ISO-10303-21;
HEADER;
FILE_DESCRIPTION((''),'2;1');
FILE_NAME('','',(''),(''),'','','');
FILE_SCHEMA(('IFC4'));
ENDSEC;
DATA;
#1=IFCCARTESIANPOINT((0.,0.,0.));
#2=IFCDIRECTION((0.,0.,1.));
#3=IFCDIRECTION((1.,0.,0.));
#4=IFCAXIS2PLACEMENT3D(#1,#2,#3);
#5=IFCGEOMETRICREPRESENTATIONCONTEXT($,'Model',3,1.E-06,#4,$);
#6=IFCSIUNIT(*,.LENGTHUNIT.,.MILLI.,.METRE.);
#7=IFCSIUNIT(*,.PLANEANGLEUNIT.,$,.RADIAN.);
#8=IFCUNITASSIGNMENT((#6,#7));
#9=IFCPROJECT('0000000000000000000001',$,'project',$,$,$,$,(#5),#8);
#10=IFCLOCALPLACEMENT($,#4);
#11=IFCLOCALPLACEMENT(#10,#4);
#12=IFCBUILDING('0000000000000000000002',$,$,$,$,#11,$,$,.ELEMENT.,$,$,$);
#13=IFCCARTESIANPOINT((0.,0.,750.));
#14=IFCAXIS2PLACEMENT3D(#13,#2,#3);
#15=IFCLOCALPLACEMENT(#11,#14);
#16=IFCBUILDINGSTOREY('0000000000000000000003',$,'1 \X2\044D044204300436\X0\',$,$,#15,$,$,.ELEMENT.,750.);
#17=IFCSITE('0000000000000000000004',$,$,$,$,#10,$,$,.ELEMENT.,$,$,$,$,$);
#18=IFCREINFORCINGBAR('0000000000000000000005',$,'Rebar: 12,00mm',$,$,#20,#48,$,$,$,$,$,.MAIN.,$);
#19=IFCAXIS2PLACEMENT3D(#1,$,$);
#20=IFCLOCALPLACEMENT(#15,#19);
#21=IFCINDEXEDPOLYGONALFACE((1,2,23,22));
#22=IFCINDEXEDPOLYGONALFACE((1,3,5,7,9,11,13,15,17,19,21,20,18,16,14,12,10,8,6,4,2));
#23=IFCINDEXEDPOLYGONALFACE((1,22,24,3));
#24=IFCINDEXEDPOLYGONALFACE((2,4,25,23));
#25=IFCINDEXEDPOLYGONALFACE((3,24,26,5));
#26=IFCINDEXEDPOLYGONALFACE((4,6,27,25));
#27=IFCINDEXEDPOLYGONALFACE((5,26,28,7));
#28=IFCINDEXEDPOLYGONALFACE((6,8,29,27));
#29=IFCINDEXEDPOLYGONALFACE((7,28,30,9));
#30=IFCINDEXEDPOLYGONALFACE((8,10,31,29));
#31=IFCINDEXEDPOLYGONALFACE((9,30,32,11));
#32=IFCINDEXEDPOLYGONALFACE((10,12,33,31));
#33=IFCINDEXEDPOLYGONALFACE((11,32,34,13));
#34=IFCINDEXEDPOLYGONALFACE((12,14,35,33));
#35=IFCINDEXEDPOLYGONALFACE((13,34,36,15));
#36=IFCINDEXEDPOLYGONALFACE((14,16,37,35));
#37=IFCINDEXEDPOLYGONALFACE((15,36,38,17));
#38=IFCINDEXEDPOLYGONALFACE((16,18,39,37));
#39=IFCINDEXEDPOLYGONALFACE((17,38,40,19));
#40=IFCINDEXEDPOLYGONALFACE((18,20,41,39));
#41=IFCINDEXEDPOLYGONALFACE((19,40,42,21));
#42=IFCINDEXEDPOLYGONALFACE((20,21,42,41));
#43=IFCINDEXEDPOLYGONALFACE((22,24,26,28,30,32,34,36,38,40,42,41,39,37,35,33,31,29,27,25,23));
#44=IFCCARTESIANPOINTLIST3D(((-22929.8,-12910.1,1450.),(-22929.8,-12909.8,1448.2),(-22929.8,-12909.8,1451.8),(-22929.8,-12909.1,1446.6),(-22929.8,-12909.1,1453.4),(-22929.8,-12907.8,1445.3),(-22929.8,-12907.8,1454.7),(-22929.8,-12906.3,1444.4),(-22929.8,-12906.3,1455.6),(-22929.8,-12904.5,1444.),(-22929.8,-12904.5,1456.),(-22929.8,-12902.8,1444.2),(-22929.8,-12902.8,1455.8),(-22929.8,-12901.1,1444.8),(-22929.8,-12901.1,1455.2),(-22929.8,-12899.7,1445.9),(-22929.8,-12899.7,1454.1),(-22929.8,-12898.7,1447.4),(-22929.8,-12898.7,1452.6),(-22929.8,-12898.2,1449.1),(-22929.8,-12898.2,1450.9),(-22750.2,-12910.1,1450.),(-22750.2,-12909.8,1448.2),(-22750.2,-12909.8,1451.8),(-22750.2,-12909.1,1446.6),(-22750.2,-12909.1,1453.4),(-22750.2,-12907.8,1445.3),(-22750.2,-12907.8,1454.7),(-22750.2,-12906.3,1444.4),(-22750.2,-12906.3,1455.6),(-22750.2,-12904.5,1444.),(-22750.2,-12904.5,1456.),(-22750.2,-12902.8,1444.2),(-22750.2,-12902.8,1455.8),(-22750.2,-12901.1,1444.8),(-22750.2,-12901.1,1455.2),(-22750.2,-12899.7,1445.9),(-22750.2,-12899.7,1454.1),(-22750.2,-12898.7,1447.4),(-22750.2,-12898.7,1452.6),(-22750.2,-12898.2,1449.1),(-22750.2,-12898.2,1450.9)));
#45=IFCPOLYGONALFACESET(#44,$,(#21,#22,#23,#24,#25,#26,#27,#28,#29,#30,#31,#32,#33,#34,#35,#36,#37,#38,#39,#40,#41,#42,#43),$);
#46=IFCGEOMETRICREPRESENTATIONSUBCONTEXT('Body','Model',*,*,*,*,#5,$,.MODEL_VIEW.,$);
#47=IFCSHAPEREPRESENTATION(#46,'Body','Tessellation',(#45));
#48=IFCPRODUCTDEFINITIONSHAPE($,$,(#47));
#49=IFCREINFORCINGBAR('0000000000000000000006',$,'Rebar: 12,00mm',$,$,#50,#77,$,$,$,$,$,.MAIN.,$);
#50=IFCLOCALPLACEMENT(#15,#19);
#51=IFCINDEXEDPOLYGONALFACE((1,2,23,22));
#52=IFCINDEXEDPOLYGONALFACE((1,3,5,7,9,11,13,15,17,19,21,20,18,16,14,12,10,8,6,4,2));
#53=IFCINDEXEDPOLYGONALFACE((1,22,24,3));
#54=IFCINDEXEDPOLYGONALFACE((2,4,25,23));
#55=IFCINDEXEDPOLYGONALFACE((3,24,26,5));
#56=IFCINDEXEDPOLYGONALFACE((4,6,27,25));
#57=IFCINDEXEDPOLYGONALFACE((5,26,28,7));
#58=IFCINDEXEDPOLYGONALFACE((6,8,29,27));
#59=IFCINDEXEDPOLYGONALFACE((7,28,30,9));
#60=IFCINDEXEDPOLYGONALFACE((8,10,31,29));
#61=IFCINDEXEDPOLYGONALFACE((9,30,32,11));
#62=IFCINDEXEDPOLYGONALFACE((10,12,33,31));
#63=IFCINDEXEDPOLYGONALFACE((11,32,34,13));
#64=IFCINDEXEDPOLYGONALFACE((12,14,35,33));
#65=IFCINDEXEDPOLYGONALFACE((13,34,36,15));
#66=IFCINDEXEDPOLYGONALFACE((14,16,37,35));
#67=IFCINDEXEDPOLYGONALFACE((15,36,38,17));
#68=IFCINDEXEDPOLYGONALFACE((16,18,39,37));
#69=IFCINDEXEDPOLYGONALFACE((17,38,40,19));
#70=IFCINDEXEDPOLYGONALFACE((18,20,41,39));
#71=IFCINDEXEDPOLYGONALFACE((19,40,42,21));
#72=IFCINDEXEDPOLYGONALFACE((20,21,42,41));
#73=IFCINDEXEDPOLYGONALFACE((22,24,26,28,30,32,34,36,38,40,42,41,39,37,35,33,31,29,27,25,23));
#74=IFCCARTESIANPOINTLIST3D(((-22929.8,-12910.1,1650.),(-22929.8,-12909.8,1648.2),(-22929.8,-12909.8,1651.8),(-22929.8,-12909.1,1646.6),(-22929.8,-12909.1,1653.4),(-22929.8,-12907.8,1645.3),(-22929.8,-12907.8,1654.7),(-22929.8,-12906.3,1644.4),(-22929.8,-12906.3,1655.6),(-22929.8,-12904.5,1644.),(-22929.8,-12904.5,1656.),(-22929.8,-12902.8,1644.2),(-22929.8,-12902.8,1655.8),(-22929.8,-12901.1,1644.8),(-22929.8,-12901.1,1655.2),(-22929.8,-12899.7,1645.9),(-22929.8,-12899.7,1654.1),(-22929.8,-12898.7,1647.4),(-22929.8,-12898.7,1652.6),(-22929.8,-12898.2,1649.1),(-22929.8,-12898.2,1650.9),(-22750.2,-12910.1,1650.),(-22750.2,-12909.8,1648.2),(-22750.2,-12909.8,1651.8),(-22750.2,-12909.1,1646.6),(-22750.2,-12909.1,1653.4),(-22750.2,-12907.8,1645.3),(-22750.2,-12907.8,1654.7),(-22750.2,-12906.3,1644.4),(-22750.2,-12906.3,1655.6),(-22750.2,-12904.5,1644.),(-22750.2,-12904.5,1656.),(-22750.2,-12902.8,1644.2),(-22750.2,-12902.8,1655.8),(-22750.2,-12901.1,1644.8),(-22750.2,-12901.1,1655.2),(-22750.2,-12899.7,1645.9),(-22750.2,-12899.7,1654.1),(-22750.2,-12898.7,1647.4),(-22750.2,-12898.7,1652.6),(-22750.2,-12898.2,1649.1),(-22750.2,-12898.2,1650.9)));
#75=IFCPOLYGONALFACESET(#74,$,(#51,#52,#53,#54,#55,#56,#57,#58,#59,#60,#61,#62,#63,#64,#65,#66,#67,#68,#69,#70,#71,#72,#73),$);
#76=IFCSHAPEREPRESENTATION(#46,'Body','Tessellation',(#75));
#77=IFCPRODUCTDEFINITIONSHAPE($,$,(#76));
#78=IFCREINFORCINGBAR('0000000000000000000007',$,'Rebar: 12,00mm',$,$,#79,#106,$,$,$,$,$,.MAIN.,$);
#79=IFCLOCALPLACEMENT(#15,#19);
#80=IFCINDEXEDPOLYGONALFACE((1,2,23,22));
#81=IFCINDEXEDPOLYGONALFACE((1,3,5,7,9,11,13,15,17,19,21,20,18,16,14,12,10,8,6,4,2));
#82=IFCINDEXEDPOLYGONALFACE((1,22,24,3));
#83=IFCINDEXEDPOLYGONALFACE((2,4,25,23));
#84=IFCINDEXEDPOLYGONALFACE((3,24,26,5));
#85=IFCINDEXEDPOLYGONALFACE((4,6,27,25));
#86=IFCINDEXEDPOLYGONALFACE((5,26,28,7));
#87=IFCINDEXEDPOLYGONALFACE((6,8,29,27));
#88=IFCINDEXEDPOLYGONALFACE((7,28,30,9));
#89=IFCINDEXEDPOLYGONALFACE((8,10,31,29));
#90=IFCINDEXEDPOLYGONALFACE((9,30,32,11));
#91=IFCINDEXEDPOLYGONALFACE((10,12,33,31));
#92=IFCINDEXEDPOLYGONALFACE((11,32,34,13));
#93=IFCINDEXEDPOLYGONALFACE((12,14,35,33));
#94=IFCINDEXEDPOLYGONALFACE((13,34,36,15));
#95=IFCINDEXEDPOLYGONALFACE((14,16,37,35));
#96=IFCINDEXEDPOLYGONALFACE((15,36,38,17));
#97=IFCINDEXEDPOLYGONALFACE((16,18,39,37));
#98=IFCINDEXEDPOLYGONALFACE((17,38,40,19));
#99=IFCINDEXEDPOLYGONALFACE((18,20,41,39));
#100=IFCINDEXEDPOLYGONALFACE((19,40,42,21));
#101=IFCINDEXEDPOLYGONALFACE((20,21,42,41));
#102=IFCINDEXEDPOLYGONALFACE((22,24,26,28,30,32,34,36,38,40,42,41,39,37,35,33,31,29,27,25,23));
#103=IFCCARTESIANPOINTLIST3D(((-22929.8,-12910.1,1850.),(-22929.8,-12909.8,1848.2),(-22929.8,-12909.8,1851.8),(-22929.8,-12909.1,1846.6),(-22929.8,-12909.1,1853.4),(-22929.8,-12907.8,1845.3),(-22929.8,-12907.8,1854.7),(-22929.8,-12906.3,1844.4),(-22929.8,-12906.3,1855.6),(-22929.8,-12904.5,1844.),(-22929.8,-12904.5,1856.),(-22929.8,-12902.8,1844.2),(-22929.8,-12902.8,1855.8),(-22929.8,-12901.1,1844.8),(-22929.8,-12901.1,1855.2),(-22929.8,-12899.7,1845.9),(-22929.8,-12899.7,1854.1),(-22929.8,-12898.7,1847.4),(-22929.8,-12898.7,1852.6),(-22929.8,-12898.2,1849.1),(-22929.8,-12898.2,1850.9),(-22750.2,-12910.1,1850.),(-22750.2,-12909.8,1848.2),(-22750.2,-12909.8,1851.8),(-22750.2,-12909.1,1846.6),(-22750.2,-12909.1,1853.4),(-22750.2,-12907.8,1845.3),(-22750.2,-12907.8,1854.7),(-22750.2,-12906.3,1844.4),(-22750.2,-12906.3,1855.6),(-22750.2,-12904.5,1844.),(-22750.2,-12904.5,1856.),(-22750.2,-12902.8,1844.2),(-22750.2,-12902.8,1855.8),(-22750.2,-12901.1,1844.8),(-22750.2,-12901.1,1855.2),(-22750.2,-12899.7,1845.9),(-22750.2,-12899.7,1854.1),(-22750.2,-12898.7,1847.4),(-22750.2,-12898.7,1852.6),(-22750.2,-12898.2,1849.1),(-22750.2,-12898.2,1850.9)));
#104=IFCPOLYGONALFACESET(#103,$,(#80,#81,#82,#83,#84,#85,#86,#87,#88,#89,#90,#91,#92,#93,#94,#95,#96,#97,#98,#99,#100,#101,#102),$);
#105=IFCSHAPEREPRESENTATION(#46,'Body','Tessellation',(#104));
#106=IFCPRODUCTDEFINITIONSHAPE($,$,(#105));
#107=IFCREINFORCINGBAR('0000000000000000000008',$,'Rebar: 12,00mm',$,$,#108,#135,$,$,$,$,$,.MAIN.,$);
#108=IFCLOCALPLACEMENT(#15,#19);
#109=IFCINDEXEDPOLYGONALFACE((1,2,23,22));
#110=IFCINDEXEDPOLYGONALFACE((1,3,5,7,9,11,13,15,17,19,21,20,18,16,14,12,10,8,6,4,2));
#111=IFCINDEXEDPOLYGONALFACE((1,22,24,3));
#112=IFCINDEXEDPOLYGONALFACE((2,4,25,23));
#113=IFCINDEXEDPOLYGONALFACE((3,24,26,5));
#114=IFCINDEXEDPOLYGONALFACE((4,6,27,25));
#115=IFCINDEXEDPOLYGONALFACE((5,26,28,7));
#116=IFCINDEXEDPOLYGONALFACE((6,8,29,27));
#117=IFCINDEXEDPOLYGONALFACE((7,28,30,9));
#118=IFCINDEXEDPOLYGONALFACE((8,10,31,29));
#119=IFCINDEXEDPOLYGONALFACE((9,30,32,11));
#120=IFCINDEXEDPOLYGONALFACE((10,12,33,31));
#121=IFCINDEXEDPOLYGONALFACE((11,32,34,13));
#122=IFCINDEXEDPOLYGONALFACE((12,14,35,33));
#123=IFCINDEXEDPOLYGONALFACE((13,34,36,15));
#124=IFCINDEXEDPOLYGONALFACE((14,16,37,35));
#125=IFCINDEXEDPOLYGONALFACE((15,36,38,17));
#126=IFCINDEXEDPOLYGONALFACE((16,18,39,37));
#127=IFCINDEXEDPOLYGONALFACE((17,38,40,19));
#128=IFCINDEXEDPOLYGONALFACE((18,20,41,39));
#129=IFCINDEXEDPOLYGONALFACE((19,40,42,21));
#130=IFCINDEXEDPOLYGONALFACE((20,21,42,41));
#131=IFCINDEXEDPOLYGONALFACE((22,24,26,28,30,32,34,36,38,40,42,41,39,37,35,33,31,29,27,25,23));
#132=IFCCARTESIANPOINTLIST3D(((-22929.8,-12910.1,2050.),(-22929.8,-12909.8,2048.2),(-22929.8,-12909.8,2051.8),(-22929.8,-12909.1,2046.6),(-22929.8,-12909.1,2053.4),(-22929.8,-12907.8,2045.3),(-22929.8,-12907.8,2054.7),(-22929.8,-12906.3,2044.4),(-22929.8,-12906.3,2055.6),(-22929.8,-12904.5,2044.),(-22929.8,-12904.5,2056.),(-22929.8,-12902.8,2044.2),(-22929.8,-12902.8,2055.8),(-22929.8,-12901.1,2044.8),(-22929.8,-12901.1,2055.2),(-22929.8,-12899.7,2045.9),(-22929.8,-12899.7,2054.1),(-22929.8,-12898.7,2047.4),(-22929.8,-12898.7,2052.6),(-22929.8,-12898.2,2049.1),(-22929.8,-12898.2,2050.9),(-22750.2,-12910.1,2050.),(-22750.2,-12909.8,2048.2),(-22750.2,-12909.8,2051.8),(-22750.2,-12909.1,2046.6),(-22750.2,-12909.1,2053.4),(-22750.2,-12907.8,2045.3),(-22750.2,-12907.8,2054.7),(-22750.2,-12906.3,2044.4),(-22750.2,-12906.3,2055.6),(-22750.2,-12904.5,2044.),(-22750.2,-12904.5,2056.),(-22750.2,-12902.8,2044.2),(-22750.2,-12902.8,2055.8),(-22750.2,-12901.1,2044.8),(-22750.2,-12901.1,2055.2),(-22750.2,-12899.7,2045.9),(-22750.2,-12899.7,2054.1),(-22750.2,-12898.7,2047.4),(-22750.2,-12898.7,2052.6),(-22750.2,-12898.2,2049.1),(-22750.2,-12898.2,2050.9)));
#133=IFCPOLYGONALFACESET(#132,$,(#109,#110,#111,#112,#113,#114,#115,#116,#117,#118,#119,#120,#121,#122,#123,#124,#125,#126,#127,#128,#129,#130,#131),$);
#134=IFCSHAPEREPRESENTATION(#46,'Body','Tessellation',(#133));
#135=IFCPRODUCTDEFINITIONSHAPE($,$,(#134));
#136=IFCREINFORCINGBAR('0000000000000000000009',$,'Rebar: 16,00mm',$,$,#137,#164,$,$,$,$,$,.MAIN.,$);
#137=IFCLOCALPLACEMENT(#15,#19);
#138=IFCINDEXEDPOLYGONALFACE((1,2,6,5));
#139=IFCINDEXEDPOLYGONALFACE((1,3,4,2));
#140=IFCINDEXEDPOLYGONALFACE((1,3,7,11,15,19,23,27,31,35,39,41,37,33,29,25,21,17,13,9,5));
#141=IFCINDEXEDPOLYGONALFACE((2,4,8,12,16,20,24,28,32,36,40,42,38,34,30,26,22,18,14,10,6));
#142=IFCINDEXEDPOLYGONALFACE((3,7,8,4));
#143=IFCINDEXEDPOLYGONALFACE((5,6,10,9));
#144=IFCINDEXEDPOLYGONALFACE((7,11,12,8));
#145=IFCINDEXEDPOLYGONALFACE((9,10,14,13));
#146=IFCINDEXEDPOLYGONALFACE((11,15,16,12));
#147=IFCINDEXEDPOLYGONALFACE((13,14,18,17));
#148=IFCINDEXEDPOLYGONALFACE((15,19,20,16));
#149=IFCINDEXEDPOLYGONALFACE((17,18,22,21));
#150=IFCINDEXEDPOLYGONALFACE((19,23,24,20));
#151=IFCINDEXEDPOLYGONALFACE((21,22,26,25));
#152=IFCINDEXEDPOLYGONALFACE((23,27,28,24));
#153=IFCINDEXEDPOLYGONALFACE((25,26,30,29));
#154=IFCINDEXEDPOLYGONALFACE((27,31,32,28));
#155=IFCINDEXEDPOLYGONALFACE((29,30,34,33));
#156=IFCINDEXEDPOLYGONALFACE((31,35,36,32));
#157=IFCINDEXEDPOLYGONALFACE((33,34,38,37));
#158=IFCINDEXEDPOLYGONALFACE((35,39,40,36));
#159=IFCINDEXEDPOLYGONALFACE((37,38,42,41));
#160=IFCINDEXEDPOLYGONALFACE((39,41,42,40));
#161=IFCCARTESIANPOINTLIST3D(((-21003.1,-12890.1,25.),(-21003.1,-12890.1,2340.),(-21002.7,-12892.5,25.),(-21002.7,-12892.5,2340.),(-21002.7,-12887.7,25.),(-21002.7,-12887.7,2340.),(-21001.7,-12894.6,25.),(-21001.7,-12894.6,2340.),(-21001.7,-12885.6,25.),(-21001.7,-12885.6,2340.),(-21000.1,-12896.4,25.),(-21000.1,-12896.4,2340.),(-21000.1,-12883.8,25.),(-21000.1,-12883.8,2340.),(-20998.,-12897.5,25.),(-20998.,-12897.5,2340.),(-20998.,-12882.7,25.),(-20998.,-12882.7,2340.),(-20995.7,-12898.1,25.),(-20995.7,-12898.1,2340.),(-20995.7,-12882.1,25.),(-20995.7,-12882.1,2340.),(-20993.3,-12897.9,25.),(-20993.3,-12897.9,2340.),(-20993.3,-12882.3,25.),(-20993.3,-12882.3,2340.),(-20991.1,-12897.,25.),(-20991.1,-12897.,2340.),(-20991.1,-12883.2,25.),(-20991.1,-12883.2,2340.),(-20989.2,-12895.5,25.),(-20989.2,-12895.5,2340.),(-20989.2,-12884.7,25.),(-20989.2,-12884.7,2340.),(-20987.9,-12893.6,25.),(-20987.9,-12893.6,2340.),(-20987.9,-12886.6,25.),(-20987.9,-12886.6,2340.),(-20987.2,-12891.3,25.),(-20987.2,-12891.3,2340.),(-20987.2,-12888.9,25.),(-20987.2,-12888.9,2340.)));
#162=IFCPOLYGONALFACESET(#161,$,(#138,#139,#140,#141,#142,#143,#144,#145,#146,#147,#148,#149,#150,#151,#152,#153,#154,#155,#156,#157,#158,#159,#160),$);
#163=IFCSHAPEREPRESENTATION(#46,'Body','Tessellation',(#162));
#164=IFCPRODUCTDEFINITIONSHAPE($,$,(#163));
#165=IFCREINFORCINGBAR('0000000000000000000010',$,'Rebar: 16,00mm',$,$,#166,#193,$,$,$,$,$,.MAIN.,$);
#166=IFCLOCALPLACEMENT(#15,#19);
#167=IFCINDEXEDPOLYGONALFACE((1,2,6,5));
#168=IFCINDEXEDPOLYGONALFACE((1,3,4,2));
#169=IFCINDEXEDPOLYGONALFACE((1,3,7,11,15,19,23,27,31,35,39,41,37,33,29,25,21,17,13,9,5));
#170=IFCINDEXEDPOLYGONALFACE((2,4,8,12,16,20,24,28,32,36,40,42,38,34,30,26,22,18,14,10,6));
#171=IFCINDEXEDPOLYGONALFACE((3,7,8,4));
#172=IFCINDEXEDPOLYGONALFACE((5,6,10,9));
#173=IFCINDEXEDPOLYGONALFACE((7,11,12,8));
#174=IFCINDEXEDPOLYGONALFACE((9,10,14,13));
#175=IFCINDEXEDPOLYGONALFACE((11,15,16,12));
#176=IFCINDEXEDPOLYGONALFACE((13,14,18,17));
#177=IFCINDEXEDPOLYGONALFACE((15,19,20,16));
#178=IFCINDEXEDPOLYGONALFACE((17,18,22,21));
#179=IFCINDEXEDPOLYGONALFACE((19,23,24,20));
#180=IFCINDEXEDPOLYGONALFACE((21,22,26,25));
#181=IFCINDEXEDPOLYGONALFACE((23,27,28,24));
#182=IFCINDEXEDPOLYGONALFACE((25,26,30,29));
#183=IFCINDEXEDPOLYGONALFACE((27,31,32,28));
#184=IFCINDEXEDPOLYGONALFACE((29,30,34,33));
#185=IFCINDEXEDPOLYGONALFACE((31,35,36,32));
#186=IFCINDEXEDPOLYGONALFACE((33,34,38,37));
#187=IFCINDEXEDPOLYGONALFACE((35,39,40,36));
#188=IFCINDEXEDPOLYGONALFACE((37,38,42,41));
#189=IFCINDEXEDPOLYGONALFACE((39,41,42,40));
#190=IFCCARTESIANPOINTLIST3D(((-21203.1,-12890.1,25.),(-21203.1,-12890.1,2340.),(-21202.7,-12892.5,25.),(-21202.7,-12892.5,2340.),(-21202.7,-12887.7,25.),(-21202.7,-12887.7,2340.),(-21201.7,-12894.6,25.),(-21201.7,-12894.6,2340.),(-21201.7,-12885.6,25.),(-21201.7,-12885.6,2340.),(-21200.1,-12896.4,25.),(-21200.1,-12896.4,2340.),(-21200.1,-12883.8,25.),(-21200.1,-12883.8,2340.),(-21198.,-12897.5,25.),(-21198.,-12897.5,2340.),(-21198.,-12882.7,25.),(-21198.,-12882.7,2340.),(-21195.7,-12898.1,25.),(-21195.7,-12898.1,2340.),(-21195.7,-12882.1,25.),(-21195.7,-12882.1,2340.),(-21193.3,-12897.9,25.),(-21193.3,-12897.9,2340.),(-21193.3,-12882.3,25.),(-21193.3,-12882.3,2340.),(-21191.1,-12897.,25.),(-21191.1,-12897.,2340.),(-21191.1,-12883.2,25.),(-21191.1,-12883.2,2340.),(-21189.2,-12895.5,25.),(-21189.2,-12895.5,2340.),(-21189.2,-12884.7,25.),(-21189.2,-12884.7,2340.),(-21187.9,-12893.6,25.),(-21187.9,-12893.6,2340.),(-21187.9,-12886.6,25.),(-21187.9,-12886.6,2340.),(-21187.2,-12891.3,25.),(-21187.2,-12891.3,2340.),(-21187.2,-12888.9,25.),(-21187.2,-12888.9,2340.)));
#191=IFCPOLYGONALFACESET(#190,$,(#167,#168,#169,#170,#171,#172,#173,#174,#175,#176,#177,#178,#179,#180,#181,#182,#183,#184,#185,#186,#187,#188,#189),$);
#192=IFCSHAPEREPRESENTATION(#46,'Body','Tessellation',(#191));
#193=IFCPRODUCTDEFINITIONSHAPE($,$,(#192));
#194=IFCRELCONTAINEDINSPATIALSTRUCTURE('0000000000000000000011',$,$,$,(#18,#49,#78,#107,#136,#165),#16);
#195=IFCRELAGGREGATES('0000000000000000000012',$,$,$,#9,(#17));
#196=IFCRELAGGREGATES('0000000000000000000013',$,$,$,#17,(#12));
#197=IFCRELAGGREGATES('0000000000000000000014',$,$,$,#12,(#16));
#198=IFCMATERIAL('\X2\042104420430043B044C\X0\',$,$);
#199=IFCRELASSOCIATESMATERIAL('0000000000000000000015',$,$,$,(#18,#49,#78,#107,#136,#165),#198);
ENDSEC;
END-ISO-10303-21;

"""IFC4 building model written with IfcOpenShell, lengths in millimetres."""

from ifc_helpers import new_model, entity, si_unit, frame, origin_with_axes, place, context, subcontext, project, spatial, source, transform, mapped, material, element, save


model = new_model("IFC4")

# Units and contexts
model_context = context("Model", 3, precision=1e-06, world=origin_with_axes())
body_context = subcontext(model_context, "Body", "Model", "MODEL_VIEW")
ifc_project = project(units=[si_unit("LENGTHUNIT", "METRE", prefix="MILLI"), si_unit("PLANEANGLEUNIT", "RADIAN")], contexts=[model_context])

# Site, building, storey
site_placement = place(None, origin_with_axes())
site = spatial("IfcSite", under=ifc_project, at=site_placement, CompositionType="ELEMENT")
building_placement = place(site_placement, origin_with_axes())
building = spatial("IfcBuilding", under=site, at=building_placement, CompositionType="ELEMENT")
storey_placement = place(building_placement, frame((0.0, 0.0, 750.0), z_axis=(0.0, 0.0, 1.0), x_axis=(1.0, 0.0, 0.0)))
storey = spatial("IfcBuildingStorey", under=building, at=storey_placement, Name="1 этаж", CompositionType="ELEMENT", Elevation=750.0)

# Reinforcing bars
ifc_material = material(Name="Сталь")
shared_shape_1 = source(origin_with_axes(), body_context, "Body", "AdvancedSweptSolid", [
    entity("IfcSweptDiskSolid", entity("IfcIndexedPolyCurve", entity("IfcCartesianPointList3D", [[0.0, 0.0, 0.0], [179.7, 0.0, 0.0]]), [entity("IfcLineIndex", [1, 2])]), 6.0),
])
reinforcing_bar_1_placement = place(storey_placement, origin_with_axes())
element("IfcReinforcingBar", 1, at=reinforcing_bar_1_placement, inside=storey, material=ifc_material, Name="Rebar: 12,00mm", PredefinedType="MAIN", context=body_context, shape_type="MappedRepresentation", body=[
    mapped(shared_shape_1, transform((-22750.2, -12904.1, 1450.0), x_axis=(-1.0, 0.0, 0.0), y_axis=(0.0, -1.0, 0.0), z_axis=(0.0, 0.0, 1.0), scale=1.0)),
])
reinforcing_bar_2_placement = place(storey_placement, origin_with_axes())
element("IfcReinforcingBar", 2, at=reinforcing_bar_2_placement, inside=storey, material=ifc_material, Name="Rebar: 12,00mm", PredefinedType="MAIN", context=body_context, shape_type="MappedRepresentation", body=[
    mapped(shared_shape_1, transform((-22750.2, -12904.1, 1650.0), x_axis=(-1.0, 0.0, 0.0), y_axis=(0.0, -1.0, 0.0), z_axis=(0.0, 0.0, 1.0), scale=1.0)),
])
reinforcing_bar_3_placement = place(storey_placement, origin_with_axes())
element("IfcReinforcingBar", 3, at=reinforcing_bar_3_placement, inside=storey, material=ifc_material, Name="Rebar: 12,00mm", PredefinedType="MAIN", context=body_context, shape_type="MappedRepresentation", body=[
    mapped(shared_shape_1, transform((-22750.2, -12904.1, 1850.0), x_axis=(-1.0, 0.0, 0.0), y_axis=(0.0, -1.0, 0.0), z_axis=(0.0, 0.0, 1.0), scale=1.0)),
])
reinforcing_bar_4_placement = place(storey_placement, origin_with_axes())
element("IfcReinforcingBar", 4, at=reinforcing_bar_4_placement, inside=storey, material=ifc_material, Name="Rebar: 12,00mm", PredefinedType="MAIN", context=body_context, shape_type="MappedRepresentation", body=[
    mapped(shared_shape_1, transform((-22750.2, -12904.1, 2050.0), x_axis=(-1.0, 0.0, 0.0), y_axis=(0.0, -1.0, 0.0), z_axis=(0.0, 0.0, 1.0), scale=1.0)),
])
shared_shape_2 = source(origin_with_axes(), body_context, "Body", "AdvancedSweptSolid", [
    entity("IfcSweptDiskSolid", entity("IfcIndexedPolyCurve", entity("IfcCartesianPointList3D", [[0.0, 0.0, 0.0], [2315.0, 0.0, 0.0]]), [entity("IfcLineIndex", [1, 2])]), 8.0),
])
reinforcing_bar_5_placement = place(storey_placement, origin_with_axes())
element("IfcReinforcingBar", 5, at=reinforcing_bar_5_placement, inside=storey, material=ifc_material, Name="Rebar: 16,00mm", PredefinedType="MAIN", context=body_context, shape_type="MappedRepresentation", body=[
    mapped(shared_shape_2, transform((-20995.1, -12890.1, 25.0), x_axis=(0.0, 0.0, 1.0), y_axis=(0.0, 1.0, 0.0), z_axis=(-1.0, 0.0, 0.0), scale=1.0)),
])
reinforcing_bar_6_placement = place(storey_placement, origin_with_axes())
element("IfcReinforcingBar", 6, at=reinforcing_bar_6_placement, inside=storey, material=ifc_material, Name="Rebar: 16,00mm", PredefinedType="MAIN", context=body_context, shape_type="MappedRepresentation", body=[
    mapped(shared_shape_2, transform((-21195.1, -12890.1, 25.0), x_axis=(0.0, 0.0, 1.0), y_axis=(0.0, 1.0, 0.0), z_axis=(-1.0, 0.0, 0.0), scale=1.0)),
])

save(model, "model.ifc")
